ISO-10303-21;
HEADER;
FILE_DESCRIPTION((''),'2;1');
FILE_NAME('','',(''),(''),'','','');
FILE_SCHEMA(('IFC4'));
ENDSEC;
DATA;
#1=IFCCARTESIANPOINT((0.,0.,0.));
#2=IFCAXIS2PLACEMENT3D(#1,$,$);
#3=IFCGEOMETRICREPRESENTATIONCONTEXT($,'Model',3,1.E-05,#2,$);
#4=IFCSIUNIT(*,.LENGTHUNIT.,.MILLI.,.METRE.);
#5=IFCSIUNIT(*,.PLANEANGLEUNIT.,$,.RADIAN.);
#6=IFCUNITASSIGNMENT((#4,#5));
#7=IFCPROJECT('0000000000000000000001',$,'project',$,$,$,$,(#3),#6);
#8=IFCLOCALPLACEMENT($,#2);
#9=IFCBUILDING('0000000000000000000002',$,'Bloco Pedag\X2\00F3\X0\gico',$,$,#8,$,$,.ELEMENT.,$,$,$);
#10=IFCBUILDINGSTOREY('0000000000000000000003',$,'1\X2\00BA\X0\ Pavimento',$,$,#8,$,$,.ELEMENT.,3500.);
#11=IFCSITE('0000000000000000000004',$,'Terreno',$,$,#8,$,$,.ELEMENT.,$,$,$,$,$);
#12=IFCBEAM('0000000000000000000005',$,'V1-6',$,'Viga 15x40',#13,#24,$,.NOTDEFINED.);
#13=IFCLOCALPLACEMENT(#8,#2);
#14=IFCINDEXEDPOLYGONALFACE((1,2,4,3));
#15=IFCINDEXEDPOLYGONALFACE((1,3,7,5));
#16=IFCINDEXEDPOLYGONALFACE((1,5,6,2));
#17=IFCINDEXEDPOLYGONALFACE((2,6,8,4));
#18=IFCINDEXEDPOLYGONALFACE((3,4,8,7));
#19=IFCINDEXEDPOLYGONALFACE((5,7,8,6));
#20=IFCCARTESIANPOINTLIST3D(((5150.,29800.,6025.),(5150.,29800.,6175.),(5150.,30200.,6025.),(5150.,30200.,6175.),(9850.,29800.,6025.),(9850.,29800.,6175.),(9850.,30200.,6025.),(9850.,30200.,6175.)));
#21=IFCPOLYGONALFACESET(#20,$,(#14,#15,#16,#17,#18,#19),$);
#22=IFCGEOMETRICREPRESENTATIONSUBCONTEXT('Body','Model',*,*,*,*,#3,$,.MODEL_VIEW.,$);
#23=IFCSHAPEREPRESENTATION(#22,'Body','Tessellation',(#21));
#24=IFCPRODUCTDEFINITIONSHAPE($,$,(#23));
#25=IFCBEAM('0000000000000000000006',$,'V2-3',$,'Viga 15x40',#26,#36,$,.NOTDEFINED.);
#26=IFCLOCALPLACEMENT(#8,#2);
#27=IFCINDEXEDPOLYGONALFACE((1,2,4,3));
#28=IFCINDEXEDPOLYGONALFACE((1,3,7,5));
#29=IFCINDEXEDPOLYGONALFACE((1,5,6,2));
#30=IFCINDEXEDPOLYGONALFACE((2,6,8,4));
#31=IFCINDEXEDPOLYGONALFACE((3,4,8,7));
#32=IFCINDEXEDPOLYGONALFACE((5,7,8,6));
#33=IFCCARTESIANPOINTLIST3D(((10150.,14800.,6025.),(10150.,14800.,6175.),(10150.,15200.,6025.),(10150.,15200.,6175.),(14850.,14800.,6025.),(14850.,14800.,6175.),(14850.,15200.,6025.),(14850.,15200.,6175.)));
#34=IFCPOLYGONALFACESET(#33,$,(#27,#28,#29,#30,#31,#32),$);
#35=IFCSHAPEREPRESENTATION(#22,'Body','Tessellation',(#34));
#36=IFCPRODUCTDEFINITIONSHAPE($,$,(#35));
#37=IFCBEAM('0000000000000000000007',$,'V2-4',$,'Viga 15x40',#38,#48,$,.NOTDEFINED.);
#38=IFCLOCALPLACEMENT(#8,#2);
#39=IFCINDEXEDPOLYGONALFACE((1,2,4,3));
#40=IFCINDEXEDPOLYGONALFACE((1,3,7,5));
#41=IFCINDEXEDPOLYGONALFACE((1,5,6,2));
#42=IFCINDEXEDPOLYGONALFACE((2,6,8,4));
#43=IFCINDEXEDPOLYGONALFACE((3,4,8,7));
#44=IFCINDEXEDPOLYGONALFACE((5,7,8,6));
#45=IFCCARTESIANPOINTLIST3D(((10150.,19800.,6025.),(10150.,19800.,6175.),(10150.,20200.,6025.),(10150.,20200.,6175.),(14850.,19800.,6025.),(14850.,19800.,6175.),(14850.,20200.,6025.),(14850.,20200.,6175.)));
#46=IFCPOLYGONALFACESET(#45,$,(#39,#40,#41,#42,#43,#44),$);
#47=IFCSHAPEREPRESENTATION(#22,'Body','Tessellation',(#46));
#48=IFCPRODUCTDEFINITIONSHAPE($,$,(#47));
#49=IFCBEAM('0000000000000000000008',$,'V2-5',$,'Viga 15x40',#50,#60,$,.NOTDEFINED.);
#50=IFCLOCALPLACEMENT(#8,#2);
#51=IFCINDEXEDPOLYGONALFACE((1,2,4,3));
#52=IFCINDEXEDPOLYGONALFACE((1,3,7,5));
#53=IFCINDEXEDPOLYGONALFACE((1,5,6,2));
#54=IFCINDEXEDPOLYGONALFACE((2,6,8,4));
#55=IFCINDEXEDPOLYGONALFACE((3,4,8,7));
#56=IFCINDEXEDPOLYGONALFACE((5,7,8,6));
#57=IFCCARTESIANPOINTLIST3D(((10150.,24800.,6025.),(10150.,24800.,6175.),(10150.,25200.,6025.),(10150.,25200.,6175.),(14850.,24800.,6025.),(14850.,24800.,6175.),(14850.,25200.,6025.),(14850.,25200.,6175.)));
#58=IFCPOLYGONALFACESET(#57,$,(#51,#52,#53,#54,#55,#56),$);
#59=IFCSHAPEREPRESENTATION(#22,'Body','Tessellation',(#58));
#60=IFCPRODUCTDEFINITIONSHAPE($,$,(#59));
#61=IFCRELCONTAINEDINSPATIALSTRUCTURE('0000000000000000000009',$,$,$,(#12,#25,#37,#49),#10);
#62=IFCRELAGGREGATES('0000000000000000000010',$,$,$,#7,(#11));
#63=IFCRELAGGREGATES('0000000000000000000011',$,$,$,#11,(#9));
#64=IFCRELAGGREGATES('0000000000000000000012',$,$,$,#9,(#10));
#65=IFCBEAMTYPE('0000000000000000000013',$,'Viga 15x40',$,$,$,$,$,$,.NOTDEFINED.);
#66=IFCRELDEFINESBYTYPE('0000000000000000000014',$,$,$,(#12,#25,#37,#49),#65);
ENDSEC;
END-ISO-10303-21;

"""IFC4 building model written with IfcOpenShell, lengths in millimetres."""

from ifc_helpers import new_model, si_unit, frame, origin, origin_2d, place, context, subcontext, project, spatial, rectangle, extrude, type_object, element, save


model = new_model("IFC4")

# Units and contexts
model_context = context("Model", 3, precision=1e-05, world=origin())
body_context = subcontext(model_context, "Body", "Model", "MODEL_VIEW")
ifc_project = project(units=[si_unit("LENGTHUNIT", "METRE", prefix="MILLI"), si_unit("PLANEANGLEUNIT", "RADIAN")], contexts=[model_context])

# Site, building, storey
placement = place(None, origin())
site = spatial("IfcSite", under=ifc_project, at=placement, Name="Terreno", CompositionType="ELEMENT")
building = spatial("IfcBuilding", under=site, at=placement, Name="Bloco Pedagógico", CompositionType="ELEMENT")
storey = spatial("IfcBuildingStorey", under=building, at=placement, Name="1º Pavimento", CompositionType="ELEMENT", Elevation=3500.0)

# Beams
beam_type = type_object("IfcBeamType", Name="Viga 15x40", PredefinedType="NOTDEFINED")
for number, where, z_axis, x_axis, name in (
    (1, (5150.0, 30000.0, 6100.0), (1.0, 0.0, 0.0), (0.0, 1.0, 0.0), "V1-6"),
    (2, (10150.0, 15000.0, 6100.0), (1.0, 0.0, 0.0), (0.0, 1.0, 0.0), "V2-3"),
    (3, (10150.0, 20000.0, 6100.0), (1.0, 0.0, 0.0), (0.0, 1.0, 0.0), "V2-4"),
    (4, (10150.0, 25000.0, 6100.0), (1.0, 0.0, 0.0), (0.0, 1.0, 0.0), "V2-5"),
):
    element("IfcBeam", number, at=place(None, frame(where, z_axis=z_axis, x_axis=x_axis)), inside=storey, type_object=beam_type, Name=name, ObjectType="Viga 15x40", PredefinedType="NOTDEFINED", context=body_context, shape_type="SweptSolid", body=[
        extrude(rectangle(XDim=400.0, YDim=150.0, at=origin_2d()), None, (0.0, 0.0, 1.0), 4700.0),
    ])

save(model, "model.ifc")
